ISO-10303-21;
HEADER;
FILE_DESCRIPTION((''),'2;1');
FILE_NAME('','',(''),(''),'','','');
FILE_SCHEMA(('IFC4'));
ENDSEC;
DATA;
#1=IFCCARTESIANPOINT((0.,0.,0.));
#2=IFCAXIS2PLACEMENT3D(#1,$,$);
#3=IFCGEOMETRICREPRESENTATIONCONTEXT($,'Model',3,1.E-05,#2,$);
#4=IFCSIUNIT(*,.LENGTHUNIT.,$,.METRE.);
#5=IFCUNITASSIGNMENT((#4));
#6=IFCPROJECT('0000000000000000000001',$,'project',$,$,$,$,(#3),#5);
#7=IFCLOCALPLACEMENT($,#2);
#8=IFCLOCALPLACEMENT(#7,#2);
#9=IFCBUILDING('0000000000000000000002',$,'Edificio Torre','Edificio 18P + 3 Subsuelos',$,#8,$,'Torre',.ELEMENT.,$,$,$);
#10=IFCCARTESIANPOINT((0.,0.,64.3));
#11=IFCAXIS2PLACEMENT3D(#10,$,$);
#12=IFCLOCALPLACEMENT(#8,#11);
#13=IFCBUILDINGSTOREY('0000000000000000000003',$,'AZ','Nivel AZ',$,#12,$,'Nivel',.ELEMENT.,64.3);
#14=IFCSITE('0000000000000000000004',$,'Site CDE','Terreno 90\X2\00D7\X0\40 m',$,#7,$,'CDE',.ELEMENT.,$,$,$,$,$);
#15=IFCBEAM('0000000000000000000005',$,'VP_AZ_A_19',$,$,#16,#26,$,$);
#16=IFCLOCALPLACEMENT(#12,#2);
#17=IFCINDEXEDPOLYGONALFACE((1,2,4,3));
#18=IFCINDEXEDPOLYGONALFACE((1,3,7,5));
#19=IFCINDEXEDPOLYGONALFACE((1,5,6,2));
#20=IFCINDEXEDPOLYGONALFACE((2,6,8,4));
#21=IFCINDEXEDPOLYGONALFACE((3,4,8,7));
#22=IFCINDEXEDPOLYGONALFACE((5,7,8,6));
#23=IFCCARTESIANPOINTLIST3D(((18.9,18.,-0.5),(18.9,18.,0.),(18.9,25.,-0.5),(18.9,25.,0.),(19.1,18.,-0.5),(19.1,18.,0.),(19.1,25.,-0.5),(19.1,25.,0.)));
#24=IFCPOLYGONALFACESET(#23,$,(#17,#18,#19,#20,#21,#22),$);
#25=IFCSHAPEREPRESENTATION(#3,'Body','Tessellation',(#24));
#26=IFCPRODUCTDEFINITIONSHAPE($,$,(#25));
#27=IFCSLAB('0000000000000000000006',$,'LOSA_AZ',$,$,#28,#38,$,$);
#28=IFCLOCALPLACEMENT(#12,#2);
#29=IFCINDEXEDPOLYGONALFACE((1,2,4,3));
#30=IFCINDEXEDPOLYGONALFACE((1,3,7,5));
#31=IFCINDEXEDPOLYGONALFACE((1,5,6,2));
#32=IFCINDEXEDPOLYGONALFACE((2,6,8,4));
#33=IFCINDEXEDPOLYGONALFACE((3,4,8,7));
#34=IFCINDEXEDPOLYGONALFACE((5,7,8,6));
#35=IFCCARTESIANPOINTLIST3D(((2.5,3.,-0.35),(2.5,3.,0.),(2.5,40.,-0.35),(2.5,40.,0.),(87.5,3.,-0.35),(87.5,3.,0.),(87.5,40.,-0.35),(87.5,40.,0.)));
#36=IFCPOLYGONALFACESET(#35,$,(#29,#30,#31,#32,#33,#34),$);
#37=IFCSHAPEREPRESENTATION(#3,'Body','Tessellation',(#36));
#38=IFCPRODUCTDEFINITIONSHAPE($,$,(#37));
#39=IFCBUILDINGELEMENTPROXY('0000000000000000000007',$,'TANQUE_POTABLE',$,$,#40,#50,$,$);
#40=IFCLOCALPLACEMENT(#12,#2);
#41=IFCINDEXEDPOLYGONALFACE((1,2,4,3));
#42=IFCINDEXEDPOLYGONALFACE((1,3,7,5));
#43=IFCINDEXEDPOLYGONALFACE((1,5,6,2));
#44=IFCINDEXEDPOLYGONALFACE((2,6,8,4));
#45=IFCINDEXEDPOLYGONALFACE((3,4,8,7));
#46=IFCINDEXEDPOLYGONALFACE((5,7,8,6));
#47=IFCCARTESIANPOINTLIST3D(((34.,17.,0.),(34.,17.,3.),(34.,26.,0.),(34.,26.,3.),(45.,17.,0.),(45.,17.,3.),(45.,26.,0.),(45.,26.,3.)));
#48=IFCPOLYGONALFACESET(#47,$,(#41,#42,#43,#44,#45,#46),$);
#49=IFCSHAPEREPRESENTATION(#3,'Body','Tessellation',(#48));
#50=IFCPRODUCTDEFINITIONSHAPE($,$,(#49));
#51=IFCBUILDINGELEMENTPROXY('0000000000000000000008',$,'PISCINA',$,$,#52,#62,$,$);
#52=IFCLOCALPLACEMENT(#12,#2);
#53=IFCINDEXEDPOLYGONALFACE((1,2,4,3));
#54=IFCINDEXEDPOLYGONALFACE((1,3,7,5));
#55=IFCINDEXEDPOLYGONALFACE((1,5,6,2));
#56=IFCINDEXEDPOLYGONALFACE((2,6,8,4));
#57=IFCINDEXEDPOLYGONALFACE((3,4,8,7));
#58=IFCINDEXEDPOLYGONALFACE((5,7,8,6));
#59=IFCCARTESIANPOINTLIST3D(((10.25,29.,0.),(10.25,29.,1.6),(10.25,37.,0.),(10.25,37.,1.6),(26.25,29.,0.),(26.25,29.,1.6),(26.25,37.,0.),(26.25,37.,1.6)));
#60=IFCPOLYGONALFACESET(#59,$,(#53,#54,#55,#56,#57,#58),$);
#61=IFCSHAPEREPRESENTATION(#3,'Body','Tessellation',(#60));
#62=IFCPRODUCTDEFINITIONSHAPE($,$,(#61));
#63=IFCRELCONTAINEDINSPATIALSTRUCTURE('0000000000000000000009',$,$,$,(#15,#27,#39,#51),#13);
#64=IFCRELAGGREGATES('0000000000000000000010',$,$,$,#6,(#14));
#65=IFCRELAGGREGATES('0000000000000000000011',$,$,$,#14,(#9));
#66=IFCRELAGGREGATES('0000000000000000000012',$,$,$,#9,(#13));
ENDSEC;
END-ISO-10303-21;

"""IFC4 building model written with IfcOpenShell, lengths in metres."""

from ifc_helpers import new_model, si_unit, frame, origin, origin_2d, place, context, project, spatial, rectangle, extrude, element, save


model = new_model("IFC4")

# Units and contexts
model_context = context("Model", 3, precision=1e-05, world=origin())
ifc_project = project(units=[si_unit("LENGTHUNIT", "METRE")], contexts=[model_context])

# Site, building, storey
site_placement = place(None, origin())
site = spatial("IfcSite", under=ifc_project, at=site_placement, Name="Site CDE", Description="Terreno 90×40 m", LongName="CDE", CompositionType="ELEMENT")
building_placement = place(site_placement, origin())
building = spatial("IfcBuilding", under=site, at=building_placement, Name="Edificio Torre", Description="Edificio 18P + 3 Subsuelos", LongName="Torre", CompositionType="ELEMENT")
storey_placement = place(building_placement, frame((0.0, 0.0, 64.3)))
storey = spatial("IfcBuildingStorey", under=building, at=storey_placement, Name="AZ", Description="Nivel AZ", LongName="Nivel", CompositionType="ELEMENT", Elevation=64.3)

# Beam
beam_1_placement = place(storey_placement, frame((19.0, 21.5, -0.5)))
element("IfcBeam", 1, at=beam_1_placement, inside=storey, Name="VP_AZ_A_19", context=model_context, shape_type="SweptSolid", body=[
    extrude(rectangle(XDim=0.2, YDim=7.0, at=origin_2d()), origin(), (0.0, 0.0, 1.0), 0.5),
])

# Slab
slab_placement = place(storey_placement, frame((45.0, 21.5, -0.35)))
element("IfcSlab", 2, at=slab_placement, inside=storey, Name="LOSA_AZ", context=model_context, shape_type="SweptSolid", body=[
    extrude(rectangle(XDim=85.0, YDim=37.0, at=origin_2d()), origin(), (0.0, 0.0, 1.0), 0.35),
])

# Building element proxies
proxy_1_placement = place(storey_placement, frame((39.5, 21.5, 0.0)))
element("IfcBuildingElementProxy", 3, at=proxy_1_placement, inside=storey, Name="TANQUE_POTABLE", context=model_context, shape_type="SweptSolid", body=[
    extrude(rectangle(XDim=11.0, YDim=9.0, at=origin_2d()), origin(), (0.0, 0.0, 1.0), 3.0),
])
proxy_2_placement = place(storey_placement, frame((18.25, 33.0, 0.0)))
element("IfcBuildingElementProxy", 4, at=proxy_2_placement, inside=storey, Name="PISCINA", context=model_context, shape_type="SweptSolid", body=[
    extrude(rectangle(XDim=16.0, YDim=8.0, at=origin_2d()), origin(), (0.0, 0.0, 1.0), 1.6),
])

save(model, "model.ifc")
